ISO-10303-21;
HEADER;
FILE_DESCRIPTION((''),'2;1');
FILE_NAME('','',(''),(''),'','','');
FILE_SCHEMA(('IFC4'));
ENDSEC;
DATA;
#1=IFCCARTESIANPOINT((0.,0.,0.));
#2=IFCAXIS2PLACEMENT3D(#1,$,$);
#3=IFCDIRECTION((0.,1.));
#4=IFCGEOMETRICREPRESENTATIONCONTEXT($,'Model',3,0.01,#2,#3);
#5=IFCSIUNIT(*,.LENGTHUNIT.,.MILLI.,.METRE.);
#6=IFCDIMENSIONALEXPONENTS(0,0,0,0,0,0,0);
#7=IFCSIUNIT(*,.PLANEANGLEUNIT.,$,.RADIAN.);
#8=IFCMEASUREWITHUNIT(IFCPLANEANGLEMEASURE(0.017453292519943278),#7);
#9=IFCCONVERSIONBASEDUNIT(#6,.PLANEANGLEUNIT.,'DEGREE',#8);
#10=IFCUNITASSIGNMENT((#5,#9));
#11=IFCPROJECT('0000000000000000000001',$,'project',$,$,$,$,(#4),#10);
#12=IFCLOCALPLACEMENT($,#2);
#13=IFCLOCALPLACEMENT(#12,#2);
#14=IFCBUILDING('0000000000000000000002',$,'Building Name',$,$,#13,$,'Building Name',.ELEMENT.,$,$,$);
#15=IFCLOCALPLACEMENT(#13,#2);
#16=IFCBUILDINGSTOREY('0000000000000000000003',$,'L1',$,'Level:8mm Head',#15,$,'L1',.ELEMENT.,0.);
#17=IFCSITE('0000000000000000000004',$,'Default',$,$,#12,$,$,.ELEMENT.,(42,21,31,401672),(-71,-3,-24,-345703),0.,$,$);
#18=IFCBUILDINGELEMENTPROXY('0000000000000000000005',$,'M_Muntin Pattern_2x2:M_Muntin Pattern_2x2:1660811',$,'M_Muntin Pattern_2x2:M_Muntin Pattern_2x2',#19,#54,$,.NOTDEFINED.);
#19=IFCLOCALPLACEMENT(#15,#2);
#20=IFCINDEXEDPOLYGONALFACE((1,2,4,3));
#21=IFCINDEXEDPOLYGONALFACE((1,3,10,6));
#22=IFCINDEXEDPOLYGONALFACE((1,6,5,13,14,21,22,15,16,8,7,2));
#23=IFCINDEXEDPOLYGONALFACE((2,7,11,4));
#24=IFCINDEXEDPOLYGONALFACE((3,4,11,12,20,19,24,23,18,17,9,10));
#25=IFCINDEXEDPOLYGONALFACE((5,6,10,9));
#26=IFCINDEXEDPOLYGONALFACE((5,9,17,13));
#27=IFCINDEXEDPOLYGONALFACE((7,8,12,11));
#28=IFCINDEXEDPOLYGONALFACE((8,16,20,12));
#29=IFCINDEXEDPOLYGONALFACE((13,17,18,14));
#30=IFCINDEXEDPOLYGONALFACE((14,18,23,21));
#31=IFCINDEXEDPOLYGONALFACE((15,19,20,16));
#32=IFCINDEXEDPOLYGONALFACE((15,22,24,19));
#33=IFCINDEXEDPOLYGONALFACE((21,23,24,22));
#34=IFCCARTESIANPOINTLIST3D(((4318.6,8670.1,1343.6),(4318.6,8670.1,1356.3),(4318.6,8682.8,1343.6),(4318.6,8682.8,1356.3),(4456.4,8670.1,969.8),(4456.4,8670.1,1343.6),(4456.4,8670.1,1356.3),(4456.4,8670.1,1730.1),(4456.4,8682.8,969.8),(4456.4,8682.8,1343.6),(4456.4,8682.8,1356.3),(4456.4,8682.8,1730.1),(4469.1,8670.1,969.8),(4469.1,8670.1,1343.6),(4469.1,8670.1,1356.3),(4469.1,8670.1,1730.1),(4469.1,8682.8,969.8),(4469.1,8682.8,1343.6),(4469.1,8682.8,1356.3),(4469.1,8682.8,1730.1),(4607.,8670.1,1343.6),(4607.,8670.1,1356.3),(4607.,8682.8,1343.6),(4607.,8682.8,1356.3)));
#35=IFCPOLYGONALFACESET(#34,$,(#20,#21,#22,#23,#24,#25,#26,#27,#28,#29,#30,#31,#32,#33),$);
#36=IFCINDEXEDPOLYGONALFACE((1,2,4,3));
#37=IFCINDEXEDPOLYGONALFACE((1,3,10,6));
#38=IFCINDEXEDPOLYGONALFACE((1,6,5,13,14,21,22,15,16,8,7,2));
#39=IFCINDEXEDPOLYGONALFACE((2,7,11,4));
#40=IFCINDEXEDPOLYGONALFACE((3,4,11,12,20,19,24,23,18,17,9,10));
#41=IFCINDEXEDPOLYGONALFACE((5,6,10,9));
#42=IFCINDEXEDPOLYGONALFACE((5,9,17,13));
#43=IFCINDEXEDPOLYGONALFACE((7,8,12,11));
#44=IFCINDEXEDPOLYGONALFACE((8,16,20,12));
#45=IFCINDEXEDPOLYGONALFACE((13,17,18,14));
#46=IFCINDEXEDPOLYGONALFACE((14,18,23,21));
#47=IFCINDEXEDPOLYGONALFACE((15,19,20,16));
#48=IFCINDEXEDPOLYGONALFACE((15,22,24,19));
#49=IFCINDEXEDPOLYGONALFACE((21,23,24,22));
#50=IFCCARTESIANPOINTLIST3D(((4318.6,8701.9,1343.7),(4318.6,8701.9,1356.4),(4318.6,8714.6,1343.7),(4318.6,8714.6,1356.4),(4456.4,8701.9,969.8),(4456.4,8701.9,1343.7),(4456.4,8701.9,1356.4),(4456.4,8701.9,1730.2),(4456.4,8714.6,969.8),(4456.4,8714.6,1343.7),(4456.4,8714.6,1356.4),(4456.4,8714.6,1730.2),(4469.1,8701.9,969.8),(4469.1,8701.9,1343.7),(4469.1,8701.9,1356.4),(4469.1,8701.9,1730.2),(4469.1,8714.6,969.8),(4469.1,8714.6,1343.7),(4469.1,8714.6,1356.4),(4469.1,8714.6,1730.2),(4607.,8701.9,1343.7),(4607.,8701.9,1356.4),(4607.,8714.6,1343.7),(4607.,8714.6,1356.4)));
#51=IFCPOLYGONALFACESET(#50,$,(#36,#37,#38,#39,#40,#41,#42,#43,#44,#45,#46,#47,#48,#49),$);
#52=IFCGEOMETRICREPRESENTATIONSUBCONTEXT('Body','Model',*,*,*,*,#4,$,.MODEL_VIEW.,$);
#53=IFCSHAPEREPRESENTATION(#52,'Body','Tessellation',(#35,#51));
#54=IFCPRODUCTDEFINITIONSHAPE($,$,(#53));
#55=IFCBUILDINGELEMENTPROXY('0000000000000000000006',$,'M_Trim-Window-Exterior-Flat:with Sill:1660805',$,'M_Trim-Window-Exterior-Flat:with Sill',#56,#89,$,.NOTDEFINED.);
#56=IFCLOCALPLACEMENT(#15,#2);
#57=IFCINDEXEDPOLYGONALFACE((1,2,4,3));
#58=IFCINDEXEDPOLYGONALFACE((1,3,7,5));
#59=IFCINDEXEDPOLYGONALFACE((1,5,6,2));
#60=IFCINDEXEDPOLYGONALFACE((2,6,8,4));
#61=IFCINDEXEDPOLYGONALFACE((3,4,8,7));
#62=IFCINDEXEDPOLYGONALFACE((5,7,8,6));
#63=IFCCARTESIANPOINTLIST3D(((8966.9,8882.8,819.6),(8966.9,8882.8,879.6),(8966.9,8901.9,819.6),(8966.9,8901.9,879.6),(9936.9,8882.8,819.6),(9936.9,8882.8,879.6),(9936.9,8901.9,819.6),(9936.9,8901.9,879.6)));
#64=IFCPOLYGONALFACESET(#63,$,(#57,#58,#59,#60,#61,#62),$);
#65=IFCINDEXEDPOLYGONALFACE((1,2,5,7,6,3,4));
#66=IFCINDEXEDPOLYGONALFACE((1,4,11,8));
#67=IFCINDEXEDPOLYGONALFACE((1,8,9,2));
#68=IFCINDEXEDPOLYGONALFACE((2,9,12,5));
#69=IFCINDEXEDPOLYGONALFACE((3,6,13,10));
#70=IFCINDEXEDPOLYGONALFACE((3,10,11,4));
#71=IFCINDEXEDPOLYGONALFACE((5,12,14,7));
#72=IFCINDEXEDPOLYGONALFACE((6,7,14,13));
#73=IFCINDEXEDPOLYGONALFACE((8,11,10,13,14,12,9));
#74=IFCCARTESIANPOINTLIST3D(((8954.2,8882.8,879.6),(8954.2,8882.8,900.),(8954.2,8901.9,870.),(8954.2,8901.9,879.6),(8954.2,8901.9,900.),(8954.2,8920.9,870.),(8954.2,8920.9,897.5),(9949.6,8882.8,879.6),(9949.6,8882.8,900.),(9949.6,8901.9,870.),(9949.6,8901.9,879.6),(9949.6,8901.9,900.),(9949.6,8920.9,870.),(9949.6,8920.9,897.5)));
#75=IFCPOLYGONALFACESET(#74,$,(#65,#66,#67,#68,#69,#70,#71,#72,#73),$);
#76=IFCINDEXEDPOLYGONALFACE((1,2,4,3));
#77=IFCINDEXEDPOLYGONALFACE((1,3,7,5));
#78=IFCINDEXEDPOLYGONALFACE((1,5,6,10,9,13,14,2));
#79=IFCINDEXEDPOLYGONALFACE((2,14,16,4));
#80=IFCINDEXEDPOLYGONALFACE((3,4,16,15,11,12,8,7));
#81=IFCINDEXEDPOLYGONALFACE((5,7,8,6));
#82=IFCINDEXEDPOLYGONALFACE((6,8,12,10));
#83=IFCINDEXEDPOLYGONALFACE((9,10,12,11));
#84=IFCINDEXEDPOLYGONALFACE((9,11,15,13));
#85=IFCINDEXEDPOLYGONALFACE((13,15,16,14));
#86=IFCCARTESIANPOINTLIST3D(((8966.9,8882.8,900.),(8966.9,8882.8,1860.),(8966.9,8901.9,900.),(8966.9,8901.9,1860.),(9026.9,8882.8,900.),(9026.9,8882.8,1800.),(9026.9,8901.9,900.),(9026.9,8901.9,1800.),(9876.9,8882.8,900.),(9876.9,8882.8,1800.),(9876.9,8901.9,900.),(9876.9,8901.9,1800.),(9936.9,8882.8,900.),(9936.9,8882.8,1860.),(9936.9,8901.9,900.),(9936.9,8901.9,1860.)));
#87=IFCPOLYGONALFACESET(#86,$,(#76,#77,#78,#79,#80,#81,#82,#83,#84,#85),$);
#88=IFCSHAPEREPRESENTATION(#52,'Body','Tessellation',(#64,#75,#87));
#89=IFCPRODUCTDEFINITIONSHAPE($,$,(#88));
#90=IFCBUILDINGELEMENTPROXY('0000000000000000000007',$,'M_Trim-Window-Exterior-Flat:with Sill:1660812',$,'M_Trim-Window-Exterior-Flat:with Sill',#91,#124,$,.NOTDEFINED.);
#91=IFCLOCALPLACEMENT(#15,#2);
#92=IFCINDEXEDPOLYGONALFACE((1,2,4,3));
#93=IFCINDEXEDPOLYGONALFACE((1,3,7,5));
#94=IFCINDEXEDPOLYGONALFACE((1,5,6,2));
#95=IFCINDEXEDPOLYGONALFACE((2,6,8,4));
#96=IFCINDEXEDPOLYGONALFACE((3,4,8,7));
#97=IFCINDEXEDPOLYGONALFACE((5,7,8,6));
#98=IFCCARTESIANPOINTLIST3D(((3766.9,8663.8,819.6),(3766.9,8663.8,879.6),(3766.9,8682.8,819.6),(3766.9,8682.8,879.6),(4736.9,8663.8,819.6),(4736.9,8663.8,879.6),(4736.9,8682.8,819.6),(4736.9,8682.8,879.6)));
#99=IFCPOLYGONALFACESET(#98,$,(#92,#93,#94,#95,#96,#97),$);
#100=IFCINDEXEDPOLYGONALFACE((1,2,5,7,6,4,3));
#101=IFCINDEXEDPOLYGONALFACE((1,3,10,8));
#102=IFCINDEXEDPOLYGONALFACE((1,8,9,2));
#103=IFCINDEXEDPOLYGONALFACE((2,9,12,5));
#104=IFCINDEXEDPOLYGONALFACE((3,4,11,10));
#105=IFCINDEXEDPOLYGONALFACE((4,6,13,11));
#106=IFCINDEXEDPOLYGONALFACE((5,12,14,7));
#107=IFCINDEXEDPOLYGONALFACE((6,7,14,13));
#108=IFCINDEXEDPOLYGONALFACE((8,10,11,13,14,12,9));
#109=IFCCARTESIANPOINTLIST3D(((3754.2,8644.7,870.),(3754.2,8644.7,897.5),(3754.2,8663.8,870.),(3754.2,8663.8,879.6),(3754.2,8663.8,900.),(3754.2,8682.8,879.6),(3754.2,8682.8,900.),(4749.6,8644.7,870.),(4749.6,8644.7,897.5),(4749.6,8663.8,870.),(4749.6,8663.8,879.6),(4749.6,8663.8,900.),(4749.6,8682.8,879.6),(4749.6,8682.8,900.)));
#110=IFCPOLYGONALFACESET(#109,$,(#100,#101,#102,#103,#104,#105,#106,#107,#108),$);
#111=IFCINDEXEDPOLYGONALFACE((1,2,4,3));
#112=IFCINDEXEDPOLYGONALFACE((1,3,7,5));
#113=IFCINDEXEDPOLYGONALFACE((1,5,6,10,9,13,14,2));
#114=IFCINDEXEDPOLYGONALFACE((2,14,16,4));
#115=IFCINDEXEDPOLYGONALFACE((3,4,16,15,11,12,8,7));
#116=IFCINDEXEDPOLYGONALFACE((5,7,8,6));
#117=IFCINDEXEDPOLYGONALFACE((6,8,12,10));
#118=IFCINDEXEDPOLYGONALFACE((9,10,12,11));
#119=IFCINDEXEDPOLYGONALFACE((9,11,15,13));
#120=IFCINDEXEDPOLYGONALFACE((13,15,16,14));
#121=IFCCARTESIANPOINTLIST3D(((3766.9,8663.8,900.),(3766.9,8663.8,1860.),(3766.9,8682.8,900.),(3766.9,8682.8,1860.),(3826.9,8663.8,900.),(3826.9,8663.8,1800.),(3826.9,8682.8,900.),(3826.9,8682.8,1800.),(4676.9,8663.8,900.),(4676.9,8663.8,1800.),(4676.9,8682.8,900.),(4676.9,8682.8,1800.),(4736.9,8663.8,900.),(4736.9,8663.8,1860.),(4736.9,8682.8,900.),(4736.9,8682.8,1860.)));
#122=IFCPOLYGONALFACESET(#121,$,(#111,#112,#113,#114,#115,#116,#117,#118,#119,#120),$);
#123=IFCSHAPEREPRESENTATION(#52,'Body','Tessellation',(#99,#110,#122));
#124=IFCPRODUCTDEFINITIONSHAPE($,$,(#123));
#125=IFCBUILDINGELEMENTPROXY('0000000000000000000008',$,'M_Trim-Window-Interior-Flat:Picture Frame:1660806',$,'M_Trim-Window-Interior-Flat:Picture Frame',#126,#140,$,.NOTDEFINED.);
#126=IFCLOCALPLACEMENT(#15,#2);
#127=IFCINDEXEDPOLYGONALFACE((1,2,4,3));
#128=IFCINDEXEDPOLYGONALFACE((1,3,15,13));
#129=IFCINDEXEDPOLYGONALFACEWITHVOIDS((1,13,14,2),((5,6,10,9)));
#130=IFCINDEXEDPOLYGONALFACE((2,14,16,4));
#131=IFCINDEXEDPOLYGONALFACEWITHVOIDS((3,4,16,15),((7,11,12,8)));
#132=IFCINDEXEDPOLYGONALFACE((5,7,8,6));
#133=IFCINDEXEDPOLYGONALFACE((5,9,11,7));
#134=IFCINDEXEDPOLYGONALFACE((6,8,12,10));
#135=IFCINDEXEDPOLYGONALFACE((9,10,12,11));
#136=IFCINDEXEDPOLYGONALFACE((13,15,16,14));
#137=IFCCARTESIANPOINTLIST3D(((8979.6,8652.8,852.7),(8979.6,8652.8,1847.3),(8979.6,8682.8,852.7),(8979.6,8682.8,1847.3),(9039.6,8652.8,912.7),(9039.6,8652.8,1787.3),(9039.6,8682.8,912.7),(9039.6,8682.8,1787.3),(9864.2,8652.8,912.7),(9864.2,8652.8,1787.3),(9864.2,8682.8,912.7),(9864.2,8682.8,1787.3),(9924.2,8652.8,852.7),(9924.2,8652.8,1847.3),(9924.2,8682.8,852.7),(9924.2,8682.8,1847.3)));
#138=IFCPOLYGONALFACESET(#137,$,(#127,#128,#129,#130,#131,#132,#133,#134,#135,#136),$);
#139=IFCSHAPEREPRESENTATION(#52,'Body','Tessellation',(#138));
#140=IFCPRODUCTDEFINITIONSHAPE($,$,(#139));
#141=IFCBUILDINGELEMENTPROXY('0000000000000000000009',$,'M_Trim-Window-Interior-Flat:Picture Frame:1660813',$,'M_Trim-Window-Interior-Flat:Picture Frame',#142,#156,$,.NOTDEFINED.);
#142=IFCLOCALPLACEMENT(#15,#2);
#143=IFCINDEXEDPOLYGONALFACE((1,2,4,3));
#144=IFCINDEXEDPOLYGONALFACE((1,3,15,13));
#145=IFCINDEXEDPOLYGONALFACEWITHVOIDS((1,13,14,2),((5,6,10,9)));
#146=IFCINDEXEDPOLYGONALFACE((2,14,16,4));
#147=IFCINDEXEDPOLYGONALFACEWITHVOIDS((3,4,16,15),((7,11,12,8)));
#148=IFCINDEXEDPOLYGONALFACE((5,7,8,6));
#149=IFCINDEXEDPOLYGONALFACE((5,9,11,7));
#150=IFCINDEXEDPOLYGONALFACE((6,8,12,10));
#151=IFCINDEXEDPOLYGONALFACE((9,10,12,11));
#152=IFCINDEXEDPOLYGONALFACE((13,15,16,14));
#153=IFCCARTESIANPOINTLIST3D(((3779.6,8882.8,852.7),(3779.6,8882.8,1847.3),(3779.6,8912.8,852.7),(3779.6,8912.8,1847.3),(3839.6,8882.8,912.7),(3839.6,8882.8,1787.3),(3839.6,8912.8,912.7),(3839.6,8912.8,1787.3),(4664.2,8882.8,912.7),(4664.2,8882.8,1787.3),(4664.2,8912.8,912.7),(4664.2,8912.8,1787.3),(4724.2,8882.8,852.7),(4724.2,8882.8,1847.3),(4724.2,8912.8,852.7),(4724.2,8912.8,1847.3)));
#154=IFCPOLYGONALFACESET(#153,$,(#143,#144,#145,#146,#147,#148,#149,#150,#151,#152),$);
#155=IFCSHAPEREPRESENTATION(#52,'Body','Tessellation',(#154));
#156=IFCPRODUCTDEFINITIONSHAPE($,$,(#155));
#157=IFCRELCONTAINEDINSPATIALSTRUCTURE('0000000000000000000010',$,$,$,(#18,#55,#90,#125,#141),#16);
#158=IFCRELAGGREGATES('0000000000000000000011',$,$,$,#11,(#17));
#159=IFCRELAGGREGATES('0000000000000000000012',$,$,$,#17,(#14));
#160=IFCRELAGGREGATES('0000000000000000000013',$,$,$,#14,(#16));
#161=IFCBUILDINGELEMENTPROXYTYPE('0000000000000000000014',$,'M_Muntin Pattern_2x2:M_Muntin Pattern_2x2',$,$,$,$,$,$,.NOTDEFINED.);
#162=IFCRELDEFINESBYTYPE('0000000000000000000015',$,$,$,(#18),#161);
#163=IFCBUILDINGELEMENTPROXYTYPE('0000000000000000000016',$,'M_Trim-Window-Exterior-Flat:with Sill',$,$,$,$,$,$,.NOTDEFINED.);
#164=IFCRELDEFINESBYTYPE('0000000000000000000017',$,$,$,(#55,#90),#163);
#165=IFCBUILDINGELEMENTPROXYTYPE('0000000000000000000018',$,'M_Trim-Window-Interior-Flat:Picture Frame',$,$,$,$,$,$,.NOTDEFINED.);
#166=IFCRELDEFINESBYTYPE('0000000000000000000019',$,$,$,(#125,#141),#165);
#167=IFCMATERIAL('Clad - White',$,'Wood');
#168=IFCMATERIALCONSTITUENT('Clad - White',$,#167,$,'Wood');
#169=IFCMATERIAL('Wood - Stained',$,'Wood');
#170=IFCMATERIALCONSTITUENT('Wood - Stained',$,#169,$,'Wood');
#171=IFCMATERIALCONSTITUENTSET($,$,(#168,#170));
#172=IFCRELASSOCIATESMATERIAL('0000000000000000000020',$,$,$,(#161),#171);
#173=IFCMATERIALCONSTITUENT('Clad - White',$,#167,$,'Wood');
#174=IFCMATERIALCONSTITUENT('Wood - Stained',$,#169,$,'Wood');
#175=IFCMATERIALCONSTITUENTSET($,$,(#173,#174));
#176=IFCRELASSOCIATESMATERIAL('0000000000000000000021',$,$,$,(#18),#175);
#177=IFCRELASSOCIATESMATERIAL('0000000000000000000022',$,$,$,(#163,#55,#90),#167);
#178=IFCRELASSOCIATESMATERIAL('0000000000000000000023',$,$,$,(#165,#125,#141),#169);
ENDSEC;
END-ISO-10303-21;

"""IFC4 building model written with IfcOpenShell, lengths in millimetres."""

from ifc_helpers import new_model, entity, si_unit, converted_unit, direction, frame, origin, place, context, subcontext, project, spatial, indexed_curve, outline, extrude, source, transform, mapped, material, constituent, constituent_set, type_object, type_shapes, element, save


model = new_model("IFC4")

# Units and contexts
model_context = context("Model", 3, precision=0.01, world=origin(), true_north=direction((0.0, 1.0)))
body_context = subcontext(model_context, "Body", "Model", "MODEL_VIEW")
ifc_project = project(units=[si_unit("LENGTHUNIT", "METRE", prefix="MILLI"), converted_unit("PLANEANGLEUNIT", "DEGREE", entity("IfcPlaneAngleMeasure", 0.017453292519943278), si_unit("PLANEANGLEUNIT", "RADIAN"), dimensions=[0, 0, 0, 0, 0, 0, 0])], contexts=[model_context])

# Site, building, storey
site_placement = place(None, origin())
site = spatial("IfcSite", under=ifc_project, at=site_placement, Name="Default", CompositionType="ELEMENT", RefLatitude=(42, 21, 31, 401672), RefLongitude=(-71, -3, -24, -345703), RefElevation=0.0)
building_placement = place(site_placement, origin())
building = spatial("IfcBuilding", under=site, at=building_placement, Name="Building Name", LongName="Building Name", CompositionType="ELEMENT")
storey_placement = place(building_placement, origin())
storey = spatial("IfcBuildingStorey", under=building, at=storey_placement, Name="L1", ObjectType="Level:8mm Head", LongName="L1", CompositionType="ELEMENT", Elevation=0.0)

# Building element proxies
ifc_material_1 = material(Name="Clad - White", Category="Wood")
ifc_material_2 = material(Name="Wood - Stained", Category="Wood")
ifc_constituent_1 = constituent(ifc_material_1, Name="Clad - White", Category="Wood")
ifc_constituent_2 = constituent(ifc_material_2, Name="Wood - Stained", Category="Wood")
ifc_constituent_set_1 = constituent_set(constituents=[ifc_constituent_1, ifc_constituent_2])
building_element_proxy_type_1 = type_object("IfcBuildingElementProxyType", Name="M_Muntin Pattern_2x2:M_Muntin Pattern_2x2", PredefinedType="NOTDEFINED", material=ifc_constituent_set_1)
shared_shape_1 = source(origin(), body_context, "Body", "SweptSolid", [
    extrude(outline(indexed_curve([(6.4, -6.4), (380.1, -6.4), (380.1, 6.3), (6.4, 6.3), (6.4, 144.2), (-6.3, 144.2), (-6.3, 6.3), (-380.2, 6.3), (-380.2, -6.4), (-6.3, -6.4), (-6.3, -144.2), (6.4, -144.2), (6.4, -6.4)], self_intersect=False)), frame((0.0, 9.5, 380.1), z_axis=(0.0, 1.0, 0.0), x_axis=(0.0, 0.0, 1.0)), (0.0, 0.0, 1.0), 12.7),
    extrude(outline(indexed_curve([(6.4, -6.4), (380.2, -6.4), (380.2, 6.3), (6.4, 6.3), (6.4, 144.2), (-6.3, 144.2), (-6.3, 6.3), (-380.2, 6.3), (-380.2, -6.4), (-6.3, -6.4), (-6.3, -144.2), (6.4, -144.2), (6.4, -6.4)], self_intersect=False)), frame((0.0, -22.2, 380.2), z_axis=(0.0, 1.0, 0.0), x_axis=(0.0, 0.0, 1.0)), (0.0, 0.0, 1.0), 12.7),
])
type_shapes(building_element_proxy_type_1, [shared_shape_1])
ifc_constituent_3 = constituent(ifc_material_1, Name="Clad - White", Category="Wood")
ifc_constituent_4 = constituent(ifc_material_2, Name="Wood - Stained", Category="Wood")
ifc_constituent_set_2 = constituent_set(constituents=[ifc_constituent_3, ifc_constituent_4])
proxy_1_placement = place(storey_placement, frame((4462.8, 8692.3, 969.8), z_axis=(0.0, 0.0, 1.0), x_axis=(-1.0, 0.0, 0.0)))
element("IfcBuildingElementProxy", 1, at=proxy_1_placement, inside=storey, type_object=building_element_proxy_type_1, material=ifc_constituent_set_2, Name="M_Muntin Pattern_2x2:M_Muntin Pattern_2x2:1660811", ObjectType="M_Muntin Pattern_2x2:M_Muntin Pattern_2x2", PredefinedType="NOTDEFINED", context=body_context, shape_type="MappedRepresentation", body=[
    mapped(shared_shape_1, transform((0.0, 0.0, 0.0), scale=1.0)),
])
building_element_proxy_type_2 = type_object("IfcBuildingElementProxyType", Name="M_Trim-Window-Exterior-Flat:with Sill", PredefinedType="NOTDEFINED", material=ifc_material_1)
shared_shape_2 = source(origin(), body_context, "Body", "SweptSolid", [
    extrude(outline(indexed_curve([(-485.0, -30.0), (485.0, -30.0), (485.0, 30.0), (-485.0, 30.0), (-485.0, -30.0)], self_intersect=False)), frame((0.0, -950.4, 0.0), z_axis=(0.0, 0.0, 1.0), x_axis=(-1.0, 0.0, 0.0)), (0.0, 0.0, 1.0), 19.0),
    extrude(outline(indexed_curve([(-19.0, -15.2), (0.0, -15.2), (0.0, -5.7), (19.0, -5.7), (19.0, 14.8), (0.0, 14.8), (-19.0, 12.3), (-19.0, -15.2)], self_intersect=False)), frame((-497.7, -914.8, 19.0), z_axis=(1.0, 0.0, 0.0), x_axis=(0.0, 0.0, -1.0)), (0.0, 0.0, 1.0), 995.4),
    extrude(outline(indexed_curve([(-495.0, -485.0), (465.0, -485.0), (465.0, -425.0), (-435.0, -425.0), (-435.0, 425.0), (465.0, 425.0), (465.0, 485.0), (-495.0, 485.0), (-495.0, -485.0)], self_intersect=False)), frame((0.0, -435.0, 0.0), z_axis=(0.0, 0.0, 1.0), x_axis=(0.0, -1.0, 0.0)), (0.0, 0.0, 1.0), 19.0),
])
type_shapes(building_element_proxy_type_2, [shared_shape_2])
for number, where, z_axis, x_axis, name in (
    (2, (9451.9, 8882.8, 1800.0), (0.0, 1.0, 0.0), (-1.0, 0.0, 0.0), "M_Trim-Window-Exterior-Flat:with Sill:1660805"),
    (3, (4251.9, 8682.8, 1800.0), (0.0, -1.0, 0.0), (1.0, 0.0, 0.0), "M_Trim-Window-Exterior-Flat:with Sill:1660812"),
):
    element("IfcBuildingElementProxy", number, at=place(storey_placement, frame(where, z_axis=z_axis, x_axis=x_axis)), inside=storey, type_object=building_element_proxy_type_2, material=ifc_material_1, Name=name, ObjectType="M_Trim-Window-Exterior-Flat:with Sill", PredefinedType="NOTDEFINED", context=body_context, shape_type="MappedRepresentation", body=[
        mapped(shared_shape_2, transform((0.0, 0.0, 0.0), scale=1.0)),
    ])
building_element_proxy_type_3 = type_object("IfcBuildingElementProxyType", Name="M_Trim-Window-Interior-Flat:Picture Frame", PredefinedType="NOTDEFINED", material=ifc_material_2)
shared_shape_3 = source(origin(), body_context, "Body", "SweptSolid", [
    extrude(outline(indexed_curve([(-472.3, -497.3), (472.3, -497.3), (472.3, 497.3), (-472.3, 497.3), (-472.3, -497.3)], self_intersect=False), holes=[indexed_curve([(-412.3, -437.3), (-412.3, 437.3), (412.3, 437.3), (412.3, -437.3), (-412.3, -437.3)], self_intersect=False)]), frame((0.0, -450.0, 0.0), z_axis=(0.0, 0.0, 1.0), x_axis=(-1.0, 0.0, 0.0)), (0.0, 0.0, 1.0), 30.0),
])
type_shapes(building_element_proxy_type_3, [shared_shape_3])
for number, where, z_axis, x_axis, name in (
    (4, (9451.9, 8682.8, 1800.0), (0.0, -1.0, 0.0), (1.0, 0.0, 0.0), "M_Trim-Window-Interior-Flat:Picture Frame:1660806"),
    (5, (4251.9, 8882.8, 1800.0), (0.0, 1.0, 0.0), (-1.0, 0.0, 0.0), "M_Trim-Window-Interior-Flat:Picture Frame:1660813"),
):
    element("IfcBuildingElementProxy", number, at=place(storey_placement, frame(where, z_axis=z_axis, x_axis=x_axis)), inside=storey, type_object=building_element_proxy_type_3, material=ifc_material_2, Name=name, ObjectType="M_Trim-Window-Interior-Flat:Picture Frame", PredefinedType="NOTDEFINED", context=body_context, shape_type="MappedRepresentation", body=[
        mapped(shared_shape_3, transform((0.0, 0.0, 0.0), scale=1.0)),
    ])

save(model, "model.ifc")
